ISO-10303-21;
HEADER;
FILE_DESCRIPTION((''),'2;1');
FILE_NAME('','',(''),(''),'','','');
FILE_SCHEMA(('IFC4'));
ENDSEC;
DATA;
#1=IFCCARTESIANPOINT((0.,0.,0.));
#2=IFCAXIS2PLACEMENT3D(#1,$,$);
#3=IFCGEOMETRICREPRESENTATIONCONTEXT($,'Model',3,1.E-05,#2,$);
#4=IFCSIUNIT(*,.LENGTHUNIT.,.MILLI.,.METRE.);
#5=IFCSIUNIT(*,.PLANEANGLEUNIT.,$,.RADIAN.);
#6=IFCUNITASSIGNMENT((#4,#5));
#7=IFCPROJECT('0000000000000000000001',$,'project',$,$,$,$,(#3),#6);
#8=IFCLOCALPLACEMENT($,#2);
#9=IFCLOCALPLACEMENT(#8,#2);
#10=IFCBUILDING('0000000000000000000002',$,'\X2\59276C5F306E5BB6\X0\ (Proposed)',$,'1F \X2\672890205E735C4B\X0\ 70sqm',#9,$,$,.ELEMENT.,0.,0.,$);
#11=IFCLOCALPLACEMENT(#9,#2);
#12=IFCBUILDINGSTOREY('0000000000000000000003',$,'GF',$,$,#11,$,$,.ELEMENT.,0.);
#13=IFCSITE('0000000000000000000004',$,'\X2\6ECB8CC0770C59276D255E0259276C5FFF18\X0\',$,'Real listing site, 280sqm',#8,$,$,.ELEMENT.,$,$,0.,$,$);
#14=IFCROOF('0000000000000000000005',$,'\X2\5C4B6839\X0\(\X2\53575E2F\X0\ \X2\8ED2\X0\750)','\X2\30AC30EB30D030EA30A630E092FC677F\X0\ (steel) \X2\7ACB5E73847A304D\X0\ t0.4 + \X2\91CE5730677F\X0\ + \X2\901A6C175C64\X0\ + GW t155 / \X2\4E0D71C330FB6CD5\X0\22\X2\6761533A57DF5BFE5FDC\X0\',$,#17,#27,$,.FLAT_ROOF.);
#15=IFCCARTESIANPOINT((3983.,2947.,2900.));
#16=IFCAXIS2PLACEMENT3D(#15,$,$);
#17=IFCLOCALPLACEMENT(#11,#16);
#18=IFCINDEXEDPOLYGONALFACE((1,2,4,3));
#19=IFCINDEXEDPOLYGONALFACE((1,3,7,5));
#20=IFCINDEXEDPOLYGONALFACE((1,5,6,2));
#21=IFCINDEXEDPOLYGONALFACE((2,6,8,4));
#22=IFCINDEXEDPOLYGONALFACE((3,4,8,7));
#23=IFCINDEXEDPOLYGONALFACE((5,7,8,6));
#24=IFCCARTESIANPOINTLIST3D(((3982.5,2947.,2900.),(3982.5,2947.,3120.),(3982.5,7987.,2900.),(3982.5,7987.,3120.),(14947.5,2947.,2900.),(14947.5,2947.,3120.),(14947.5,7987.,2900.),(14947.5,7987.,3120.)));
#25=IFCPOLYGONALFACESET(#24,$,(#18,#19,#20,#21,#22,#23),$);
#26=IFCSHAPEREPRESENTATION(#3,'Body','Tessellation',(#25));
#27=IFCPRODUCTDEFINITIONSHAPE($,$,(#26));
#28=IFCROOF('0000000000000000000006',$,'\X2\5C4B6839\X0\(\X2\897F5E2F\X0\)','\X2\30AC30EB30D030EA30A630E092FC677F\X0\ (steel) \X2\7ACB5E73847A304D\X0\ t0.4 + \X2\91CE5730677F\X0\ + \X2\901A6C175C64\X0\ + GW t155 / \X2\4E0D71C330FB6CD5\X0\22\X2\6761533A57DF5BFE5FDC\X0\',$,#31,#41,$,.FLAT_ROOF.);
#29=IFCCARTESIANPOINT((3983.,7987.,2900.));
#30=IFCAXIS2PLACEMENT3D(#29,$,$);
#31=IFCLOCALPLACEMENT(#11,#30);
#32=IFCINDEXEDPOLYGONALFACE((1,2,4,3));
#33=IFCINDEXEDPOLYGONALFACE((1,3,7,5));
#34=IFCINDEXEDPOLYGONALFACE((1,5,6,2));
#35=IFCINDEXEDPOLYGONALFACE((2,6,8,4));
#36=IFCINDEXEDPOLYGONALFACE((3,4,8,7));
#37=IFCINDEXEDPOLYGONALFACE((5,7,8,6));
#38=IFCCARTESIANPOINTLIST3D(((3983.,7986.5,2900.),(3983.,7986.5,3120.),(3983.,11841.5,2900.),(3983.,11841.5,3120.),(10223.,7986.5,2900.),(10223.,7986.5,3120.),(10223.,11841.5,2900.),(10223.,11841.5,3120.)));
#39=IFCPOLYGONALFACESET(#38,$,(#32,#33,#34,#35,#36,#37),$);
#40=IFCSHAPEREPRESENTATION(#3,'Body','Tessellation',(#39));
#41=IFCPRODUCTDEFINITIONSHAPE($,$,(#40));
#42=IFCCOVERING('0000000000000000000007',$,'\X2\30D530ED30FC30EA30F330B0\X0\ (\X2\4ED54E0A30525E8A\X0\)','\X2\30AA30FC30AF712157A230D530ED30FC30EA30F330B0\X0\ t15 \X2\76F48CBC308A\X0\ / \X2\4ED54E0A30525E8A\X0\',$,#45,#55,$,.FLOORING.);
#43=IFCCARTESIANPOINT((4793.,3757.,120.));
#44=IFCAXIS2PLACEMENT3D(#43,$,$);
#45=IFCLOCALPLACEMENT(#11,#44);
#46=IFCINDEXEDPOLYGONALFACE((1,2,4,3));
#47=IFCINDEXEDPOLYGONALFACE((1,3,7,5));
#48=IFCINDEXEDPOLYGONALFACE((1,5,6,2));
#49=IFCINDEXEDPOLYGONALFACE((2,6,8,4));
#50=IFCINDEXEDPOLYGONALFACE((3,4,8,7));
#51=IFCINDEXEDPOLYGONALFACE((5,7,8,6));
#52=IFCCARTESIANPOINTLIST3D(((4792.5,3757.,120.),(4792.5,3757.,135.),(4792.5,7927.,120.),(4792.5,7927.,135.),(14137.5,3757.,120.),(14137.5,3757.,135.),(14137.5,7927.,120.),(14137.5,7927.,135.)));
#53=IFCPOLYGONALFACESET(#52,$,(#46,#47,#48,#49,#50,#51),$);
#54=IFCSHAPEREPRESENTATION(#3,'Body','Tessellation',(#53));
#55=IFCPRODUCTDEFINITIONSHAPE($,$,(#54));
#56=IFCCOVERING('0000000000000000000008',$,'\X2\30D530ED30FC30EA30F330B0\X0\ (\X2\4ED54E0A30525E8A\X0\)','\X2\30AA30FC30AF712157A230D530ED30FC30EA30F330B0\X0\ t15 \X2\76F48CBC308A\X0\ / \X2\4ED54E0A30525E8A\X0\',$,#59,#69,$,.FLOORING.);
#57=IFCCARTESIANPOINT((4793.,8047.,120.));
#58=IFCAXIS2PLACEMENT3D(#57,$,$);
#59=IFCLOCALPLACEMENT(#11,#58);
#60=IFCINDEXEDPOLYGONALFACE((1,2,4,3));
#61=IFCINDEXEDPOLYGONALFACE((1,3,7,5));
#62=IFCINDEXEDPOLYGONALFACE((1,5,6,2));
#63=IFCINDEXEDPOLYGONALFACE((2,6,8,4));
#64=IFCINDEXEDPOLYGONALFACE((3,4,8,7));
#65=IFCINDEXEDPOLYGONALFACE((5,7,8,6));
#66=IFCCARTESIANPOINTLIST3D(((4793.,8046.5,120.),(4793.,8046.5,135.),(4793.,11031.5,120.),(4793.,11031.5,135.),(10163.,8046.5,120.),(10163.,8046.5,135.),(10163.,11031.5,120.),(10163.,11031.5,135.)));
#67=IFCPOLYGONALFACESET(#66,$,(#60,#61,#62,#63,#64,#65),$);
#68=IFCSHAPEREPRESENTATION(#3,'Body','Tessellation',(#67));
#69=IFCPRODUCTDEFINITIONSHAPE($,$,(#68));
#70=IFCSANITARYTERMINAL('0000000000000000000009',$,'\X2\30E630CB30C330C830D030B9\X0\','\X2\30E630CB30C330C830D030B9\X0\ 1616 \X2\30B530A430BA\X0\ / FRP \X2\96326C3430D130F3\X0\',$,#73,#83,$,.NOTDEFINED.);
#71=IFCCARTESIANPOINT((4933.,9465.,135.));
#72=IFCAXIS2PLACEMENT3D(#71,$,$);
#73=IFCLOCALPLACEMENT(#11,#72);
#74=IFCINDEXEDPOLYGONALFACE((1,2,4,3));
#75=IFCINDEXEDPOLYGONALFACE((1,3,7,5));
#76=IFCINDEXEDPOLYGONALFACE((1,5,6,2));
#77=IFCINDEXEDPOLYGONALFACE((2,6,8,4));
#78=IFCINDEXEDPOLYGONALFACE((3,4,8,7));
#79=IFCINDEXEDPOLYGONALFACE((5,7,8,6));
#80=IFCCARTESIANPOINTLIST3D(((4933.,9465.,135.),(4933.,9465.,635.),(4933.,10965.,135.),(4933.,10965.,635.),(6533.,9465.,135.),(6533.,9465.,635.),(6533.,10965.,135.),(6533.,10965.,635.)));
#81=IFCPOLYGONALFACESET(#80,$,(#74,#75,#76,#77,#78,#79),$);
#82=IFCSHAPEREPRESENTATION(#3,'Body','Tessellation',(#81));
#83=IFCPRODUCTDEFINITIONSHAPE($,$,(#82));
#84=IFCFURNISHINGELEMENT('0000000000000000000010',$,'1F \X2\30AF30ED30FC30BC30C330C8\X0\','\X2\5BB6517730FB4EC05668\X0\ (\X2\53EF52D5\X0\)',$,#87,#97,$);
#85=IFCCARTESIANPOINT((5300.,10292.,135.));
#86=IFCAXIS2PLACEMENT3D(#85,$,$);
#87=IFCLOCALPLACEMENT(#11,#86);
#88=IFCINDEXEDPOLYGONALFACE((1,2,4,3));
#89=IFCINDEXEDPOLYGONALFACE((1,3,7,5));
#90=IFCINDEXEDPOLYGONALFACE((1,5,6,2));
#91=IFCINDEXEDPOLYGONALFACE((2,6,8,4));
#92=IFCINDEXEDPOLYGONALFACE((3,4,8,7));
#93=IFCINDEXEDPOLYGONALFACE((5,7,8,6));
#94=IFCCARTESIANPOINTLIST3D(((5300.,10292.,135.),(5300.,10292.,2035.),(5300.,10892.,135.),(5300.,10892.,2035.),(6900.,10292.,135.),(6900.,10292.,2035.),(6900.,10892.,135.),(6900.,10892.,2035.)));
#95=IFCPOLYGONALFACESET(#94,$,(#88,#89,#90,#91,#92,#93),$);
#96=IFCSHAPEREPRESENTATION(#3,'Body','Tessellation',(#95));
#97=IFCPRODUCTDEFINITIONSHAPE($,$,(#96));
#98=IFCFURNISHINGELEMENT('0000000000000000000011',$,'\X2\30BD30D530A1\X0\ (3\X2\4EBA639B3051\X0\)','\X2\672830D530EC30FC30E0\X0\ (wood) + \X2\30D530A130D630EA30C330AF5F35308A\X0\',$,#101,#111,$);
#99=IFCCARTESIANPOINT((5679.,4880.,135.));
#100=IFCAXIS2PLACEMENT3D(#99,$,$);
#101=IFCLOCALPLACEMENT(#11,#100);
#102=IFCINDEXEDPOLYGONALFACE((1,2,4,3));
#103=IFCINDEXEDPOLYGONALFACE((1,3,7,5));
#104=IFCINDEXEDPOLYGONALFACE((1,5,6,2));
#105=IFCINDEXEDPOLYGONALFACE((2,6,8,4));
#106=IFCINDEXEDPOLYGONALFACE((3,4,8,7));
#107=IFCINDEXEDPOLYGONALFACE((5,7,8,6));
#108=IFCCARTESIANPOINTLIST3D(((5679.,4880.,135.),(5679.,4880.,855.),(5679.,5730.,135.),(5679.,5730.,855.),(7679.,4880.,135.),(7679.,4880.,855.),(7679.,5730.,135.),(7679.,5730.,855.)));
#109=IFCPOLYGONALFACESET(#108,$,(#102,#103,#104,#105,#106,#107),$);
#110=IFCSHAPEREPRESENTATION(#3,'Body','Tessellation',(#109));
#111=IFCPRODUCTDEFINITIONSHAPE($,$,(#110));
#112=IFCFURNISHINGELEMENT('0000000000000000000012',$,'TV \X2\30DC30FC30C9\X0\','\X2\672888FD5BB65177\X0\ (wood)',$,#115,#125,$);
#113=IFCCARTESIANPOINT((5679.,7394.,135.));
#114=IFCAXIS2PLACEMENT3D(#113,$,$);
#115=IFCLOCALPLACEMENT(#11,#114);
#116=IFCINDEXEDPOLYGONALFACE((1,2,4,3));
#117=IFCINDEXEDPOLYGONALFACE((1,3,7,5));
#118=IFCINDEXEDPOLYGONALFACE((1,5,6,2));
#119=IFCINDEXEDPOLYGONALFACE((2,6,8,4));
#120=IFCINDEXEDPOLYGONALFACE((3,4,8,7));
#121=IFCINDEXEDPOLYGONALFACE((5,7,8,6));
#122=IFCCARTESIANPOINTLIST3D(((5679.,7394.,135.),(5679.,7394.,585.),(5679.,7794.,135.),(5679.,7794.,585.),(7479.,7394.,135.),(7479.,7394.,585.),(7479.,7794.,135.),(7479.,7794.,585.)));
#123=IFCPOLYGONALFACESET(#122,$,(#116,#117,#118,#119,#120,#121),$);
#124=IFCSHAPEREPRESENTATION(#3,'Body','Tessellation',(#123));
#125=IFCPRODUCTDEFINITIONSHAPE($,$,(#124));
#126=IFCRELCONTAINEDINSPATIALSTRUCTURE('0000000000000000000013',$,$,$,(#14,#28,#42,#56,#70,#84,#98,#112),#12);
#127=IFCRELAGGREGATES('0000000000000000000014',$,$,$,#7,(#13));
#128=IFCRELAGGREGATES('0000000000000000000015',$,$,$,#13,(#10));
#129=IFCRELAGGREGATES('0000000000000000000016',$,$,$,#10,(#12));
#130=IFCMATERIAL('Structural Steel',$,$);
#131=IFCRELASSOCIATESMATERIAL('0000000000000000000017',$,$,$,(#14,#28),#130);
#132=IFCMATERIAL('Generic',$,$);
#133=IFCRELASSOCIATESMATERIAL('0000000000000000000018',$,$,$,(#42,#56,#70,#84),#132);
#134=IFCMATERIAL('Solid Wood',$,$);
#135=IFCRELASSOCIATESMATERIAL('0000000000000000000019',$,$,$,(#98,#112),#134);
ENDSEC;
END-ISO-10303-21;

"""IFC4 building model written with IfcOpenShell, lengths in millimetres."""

from ifc_helpers import new_model, si_unit, frame, frame_2d, origin, place, context, project, spatial, rectangle, extrude, material, element, save


model = new_model("IFC4")

# Units and contexts
model_context = context("Model", 3, precision=1e-05, world=origin())
ifc_project = project(units=[si_unit("LENGTHUNIT", "METRE", prefix="MILLI"), si_unit("PLANEANGLEUNIT", "RADIAN")], contexts=[model_context])

# Site, building, storey
site_placement = place(None, origin())
site = spatial("IfcSite", under=ifc_project, at=site_placement, Name="滋賀県大津市大江８", ObjectType="Real listing site, 280sqm", CompositionType="ELEMENT", RefElevation=0.0)
building_placement = place(site_placement, origin())
building = spatial("IfcBuilding", under=site, at=building_placement, Name="大江の家 (Proposed)", ObjectType="1F 木造平屋 70sqm", CompositionType="ELEMENT", ElevationOfRefHeight=0.0, ElevationOfTerrain=0.0)
storey_placement = place(building_placement, origin())
storey = spatial("IfcBuildingStorey", under=building, at=storey_placement, Name="GF", CompositionType="ELEMENT", Elevation=0.0)

# Shared definitions
ifc_material_1 = material(Name="Solid Wood")

# Roofs
ifc_material_2 = material(Name="Structural Steel")
roof_1_placement = place(storey_placement, frame((3983.0, 2947.0, 2900.0)))
element("IfcRoof", 1, at=roof_1_placement, inside=storey, material=ifc_material_2, Name="屋根(南帯 軒750)", Description="ガルバリウム鋼板 (steel) 立平葺き t0.4 + 野地板 + 通気層 + GW t155 / 不燃・法22条区域対応", PredefinedType="FLAT_ROOF", context=model_context, shape_type="SweptSolid", body=[
    extrude(rectangle(XDim=10965.0, YDim=5040.0, at=frame_2d((5482.0, 2520.0))), frame((3983.0, 2947.0, 2900.0)), (0.0, 0.0, 1.0), 220.0),
])
roof_2_placement = place(storey_placement, frame((3983.0, 7987.0, 2900.0)))
element("IfcRoof", 2, at=roof_2_placement, inside=storey, material=ifc_material_2, Name="屋根(西帯)", Description="ガルバリウム鋼板 (steel) 立平葺き t0.4 + 野地板 + 通気層 + GW t155 / 不燃・法22条区域対応", PredefinedType="FLAT_ROOF", context=model_context, shape_type="SweptSolid", body=[
    extrude(rectangle(XDim=6240.0, YDim=3855.0, at=frame_2d((3120.0, 1927.0))), frame((3983.0, 7987.0, 2900.0)), (0.0, 0.0, 1.0), 220.0),
])

# Coverings
ifc_material_3 = material(Name="Generic")
covering_1_placement = place(storey_placement, frame((4793.0, 3757.0, 120.0)))
element("IfcCovering", 3, at=covering_1_placement, inside=storey, material=ifc_material_3, Name="フローリング (仕上げ床)", Description="オーク無垢フローリング t15 直貼り / 仕上げ床", PredefinedType="FLOORING", context=model_context, shape_type="SweptSolid", body=[
    extrude(rectangle(XDim=9345.0, YDim=4170.0, at=frame_2d((4672.0, 2085.0))), frame((4793.0, 3757.0, 120.0)), (0.0, 0.0, 1.0), 15.0),
])
covering_2_placement = place(storey_placement, frame((4793.0, 8047.0, 120.0)))
element("IfcCovering", 4, at=covering_2_placement, inside=storey, material=ifc_material_3, Name="フローリング (仕上げ床)", Description="オーク無垢フローリング t15 直貼り / 仕上げ床", PredefinedType="FLOORING", context=model_context, shape_type="SweptSolid", body=[
    extrude(rectangle(XDim=5370.0, YDim=2985.0, at=frame_2d((2685.0, 1492.0))), frame((4793.0, 8047.0, 120.0)), (0.0, 0.0, 1.0), 15.0),
])

# Sanitary terminal
sanitary_terminal_placement = place(storey_placement, frame((4933.0, 9465.0, 135.0)))
element("IfcSanitaryTerminal", 5, at=sanitary_terminal_placement, inside=storey, material=ifc_material_3, Name="ユニットバス", Description="ユニットバス 1616 サイズ / FRP 防水パン", PredefinedType="NOTDEFINED", context=model_context, shape_type="SweptSolid", body=[
    extrude(rectangle(XDim=1600.0, YDim=1500.0, at=frame_2d((800.0, 750.0))), frame((4933.0, 9465.0, 135.0)), (0.0, 0.0, 1.0), 500.0),
])

# Furnishing elements
furnishing_1_placement = place(storey_placement, frame((5300.0, 10292.0, 135.0)))
element("IfcFurnishingElement", 6, at=furnishing_1_placement, inside=storey, material=ifc_material_3, Name="1F クローゼット", Description="家具・什器 (可動)", context=model_context, shape_type="SweptSolid", body=[
    extrude(rectangle(XDim=1600.0, YDim=600.0, at=frame_2d((800.0, 300.0))), frame((5300.0, 10292.0, 135.0)), (0.0, 0.0, 1.0), 1900.0),
])
furnishing_2_placement = place(storey_placement, frame((5679.0, 4880.0, 135.0)))
element("IfcFurnishingElement", 7, at=furnishing_2_placement, inside=storey, material=ifc_material_1, Name="ソファ (3人掛け)", Description="木フレーム (wood) + ファブリック張り", context=model_context, shape_type="SweptSolid", body=[
    extrude(rectangle(XDim=2000.0, YDim=850.0, at=frame_2d((1000.0, 425.0))), frame((5679.0, 4880.0, 135.0)), (0.0, 0.0, 1.0), 720.0),
])
furnishing_3_placement = place(storey_placement, frame((5679.0, 7394.0, 135.0)))
element("IfcFurnishingElement", 8, at=furnishing_3_placement, inside=storey, material=ifc_material_1, Name="TV ボード", Description="木製家具 (wood)", context=model_context, shape_type="SweptSolid", body=[
    extrude(rectangle(XDim=1800.0, YDim=400.0, at=frame_2d((900.0, 200.0))), frame((5679.0, 7394.0, 135.0)), (0.0, 0.0, 1.0), 450.0),
])

save(model, "model.ifc")
